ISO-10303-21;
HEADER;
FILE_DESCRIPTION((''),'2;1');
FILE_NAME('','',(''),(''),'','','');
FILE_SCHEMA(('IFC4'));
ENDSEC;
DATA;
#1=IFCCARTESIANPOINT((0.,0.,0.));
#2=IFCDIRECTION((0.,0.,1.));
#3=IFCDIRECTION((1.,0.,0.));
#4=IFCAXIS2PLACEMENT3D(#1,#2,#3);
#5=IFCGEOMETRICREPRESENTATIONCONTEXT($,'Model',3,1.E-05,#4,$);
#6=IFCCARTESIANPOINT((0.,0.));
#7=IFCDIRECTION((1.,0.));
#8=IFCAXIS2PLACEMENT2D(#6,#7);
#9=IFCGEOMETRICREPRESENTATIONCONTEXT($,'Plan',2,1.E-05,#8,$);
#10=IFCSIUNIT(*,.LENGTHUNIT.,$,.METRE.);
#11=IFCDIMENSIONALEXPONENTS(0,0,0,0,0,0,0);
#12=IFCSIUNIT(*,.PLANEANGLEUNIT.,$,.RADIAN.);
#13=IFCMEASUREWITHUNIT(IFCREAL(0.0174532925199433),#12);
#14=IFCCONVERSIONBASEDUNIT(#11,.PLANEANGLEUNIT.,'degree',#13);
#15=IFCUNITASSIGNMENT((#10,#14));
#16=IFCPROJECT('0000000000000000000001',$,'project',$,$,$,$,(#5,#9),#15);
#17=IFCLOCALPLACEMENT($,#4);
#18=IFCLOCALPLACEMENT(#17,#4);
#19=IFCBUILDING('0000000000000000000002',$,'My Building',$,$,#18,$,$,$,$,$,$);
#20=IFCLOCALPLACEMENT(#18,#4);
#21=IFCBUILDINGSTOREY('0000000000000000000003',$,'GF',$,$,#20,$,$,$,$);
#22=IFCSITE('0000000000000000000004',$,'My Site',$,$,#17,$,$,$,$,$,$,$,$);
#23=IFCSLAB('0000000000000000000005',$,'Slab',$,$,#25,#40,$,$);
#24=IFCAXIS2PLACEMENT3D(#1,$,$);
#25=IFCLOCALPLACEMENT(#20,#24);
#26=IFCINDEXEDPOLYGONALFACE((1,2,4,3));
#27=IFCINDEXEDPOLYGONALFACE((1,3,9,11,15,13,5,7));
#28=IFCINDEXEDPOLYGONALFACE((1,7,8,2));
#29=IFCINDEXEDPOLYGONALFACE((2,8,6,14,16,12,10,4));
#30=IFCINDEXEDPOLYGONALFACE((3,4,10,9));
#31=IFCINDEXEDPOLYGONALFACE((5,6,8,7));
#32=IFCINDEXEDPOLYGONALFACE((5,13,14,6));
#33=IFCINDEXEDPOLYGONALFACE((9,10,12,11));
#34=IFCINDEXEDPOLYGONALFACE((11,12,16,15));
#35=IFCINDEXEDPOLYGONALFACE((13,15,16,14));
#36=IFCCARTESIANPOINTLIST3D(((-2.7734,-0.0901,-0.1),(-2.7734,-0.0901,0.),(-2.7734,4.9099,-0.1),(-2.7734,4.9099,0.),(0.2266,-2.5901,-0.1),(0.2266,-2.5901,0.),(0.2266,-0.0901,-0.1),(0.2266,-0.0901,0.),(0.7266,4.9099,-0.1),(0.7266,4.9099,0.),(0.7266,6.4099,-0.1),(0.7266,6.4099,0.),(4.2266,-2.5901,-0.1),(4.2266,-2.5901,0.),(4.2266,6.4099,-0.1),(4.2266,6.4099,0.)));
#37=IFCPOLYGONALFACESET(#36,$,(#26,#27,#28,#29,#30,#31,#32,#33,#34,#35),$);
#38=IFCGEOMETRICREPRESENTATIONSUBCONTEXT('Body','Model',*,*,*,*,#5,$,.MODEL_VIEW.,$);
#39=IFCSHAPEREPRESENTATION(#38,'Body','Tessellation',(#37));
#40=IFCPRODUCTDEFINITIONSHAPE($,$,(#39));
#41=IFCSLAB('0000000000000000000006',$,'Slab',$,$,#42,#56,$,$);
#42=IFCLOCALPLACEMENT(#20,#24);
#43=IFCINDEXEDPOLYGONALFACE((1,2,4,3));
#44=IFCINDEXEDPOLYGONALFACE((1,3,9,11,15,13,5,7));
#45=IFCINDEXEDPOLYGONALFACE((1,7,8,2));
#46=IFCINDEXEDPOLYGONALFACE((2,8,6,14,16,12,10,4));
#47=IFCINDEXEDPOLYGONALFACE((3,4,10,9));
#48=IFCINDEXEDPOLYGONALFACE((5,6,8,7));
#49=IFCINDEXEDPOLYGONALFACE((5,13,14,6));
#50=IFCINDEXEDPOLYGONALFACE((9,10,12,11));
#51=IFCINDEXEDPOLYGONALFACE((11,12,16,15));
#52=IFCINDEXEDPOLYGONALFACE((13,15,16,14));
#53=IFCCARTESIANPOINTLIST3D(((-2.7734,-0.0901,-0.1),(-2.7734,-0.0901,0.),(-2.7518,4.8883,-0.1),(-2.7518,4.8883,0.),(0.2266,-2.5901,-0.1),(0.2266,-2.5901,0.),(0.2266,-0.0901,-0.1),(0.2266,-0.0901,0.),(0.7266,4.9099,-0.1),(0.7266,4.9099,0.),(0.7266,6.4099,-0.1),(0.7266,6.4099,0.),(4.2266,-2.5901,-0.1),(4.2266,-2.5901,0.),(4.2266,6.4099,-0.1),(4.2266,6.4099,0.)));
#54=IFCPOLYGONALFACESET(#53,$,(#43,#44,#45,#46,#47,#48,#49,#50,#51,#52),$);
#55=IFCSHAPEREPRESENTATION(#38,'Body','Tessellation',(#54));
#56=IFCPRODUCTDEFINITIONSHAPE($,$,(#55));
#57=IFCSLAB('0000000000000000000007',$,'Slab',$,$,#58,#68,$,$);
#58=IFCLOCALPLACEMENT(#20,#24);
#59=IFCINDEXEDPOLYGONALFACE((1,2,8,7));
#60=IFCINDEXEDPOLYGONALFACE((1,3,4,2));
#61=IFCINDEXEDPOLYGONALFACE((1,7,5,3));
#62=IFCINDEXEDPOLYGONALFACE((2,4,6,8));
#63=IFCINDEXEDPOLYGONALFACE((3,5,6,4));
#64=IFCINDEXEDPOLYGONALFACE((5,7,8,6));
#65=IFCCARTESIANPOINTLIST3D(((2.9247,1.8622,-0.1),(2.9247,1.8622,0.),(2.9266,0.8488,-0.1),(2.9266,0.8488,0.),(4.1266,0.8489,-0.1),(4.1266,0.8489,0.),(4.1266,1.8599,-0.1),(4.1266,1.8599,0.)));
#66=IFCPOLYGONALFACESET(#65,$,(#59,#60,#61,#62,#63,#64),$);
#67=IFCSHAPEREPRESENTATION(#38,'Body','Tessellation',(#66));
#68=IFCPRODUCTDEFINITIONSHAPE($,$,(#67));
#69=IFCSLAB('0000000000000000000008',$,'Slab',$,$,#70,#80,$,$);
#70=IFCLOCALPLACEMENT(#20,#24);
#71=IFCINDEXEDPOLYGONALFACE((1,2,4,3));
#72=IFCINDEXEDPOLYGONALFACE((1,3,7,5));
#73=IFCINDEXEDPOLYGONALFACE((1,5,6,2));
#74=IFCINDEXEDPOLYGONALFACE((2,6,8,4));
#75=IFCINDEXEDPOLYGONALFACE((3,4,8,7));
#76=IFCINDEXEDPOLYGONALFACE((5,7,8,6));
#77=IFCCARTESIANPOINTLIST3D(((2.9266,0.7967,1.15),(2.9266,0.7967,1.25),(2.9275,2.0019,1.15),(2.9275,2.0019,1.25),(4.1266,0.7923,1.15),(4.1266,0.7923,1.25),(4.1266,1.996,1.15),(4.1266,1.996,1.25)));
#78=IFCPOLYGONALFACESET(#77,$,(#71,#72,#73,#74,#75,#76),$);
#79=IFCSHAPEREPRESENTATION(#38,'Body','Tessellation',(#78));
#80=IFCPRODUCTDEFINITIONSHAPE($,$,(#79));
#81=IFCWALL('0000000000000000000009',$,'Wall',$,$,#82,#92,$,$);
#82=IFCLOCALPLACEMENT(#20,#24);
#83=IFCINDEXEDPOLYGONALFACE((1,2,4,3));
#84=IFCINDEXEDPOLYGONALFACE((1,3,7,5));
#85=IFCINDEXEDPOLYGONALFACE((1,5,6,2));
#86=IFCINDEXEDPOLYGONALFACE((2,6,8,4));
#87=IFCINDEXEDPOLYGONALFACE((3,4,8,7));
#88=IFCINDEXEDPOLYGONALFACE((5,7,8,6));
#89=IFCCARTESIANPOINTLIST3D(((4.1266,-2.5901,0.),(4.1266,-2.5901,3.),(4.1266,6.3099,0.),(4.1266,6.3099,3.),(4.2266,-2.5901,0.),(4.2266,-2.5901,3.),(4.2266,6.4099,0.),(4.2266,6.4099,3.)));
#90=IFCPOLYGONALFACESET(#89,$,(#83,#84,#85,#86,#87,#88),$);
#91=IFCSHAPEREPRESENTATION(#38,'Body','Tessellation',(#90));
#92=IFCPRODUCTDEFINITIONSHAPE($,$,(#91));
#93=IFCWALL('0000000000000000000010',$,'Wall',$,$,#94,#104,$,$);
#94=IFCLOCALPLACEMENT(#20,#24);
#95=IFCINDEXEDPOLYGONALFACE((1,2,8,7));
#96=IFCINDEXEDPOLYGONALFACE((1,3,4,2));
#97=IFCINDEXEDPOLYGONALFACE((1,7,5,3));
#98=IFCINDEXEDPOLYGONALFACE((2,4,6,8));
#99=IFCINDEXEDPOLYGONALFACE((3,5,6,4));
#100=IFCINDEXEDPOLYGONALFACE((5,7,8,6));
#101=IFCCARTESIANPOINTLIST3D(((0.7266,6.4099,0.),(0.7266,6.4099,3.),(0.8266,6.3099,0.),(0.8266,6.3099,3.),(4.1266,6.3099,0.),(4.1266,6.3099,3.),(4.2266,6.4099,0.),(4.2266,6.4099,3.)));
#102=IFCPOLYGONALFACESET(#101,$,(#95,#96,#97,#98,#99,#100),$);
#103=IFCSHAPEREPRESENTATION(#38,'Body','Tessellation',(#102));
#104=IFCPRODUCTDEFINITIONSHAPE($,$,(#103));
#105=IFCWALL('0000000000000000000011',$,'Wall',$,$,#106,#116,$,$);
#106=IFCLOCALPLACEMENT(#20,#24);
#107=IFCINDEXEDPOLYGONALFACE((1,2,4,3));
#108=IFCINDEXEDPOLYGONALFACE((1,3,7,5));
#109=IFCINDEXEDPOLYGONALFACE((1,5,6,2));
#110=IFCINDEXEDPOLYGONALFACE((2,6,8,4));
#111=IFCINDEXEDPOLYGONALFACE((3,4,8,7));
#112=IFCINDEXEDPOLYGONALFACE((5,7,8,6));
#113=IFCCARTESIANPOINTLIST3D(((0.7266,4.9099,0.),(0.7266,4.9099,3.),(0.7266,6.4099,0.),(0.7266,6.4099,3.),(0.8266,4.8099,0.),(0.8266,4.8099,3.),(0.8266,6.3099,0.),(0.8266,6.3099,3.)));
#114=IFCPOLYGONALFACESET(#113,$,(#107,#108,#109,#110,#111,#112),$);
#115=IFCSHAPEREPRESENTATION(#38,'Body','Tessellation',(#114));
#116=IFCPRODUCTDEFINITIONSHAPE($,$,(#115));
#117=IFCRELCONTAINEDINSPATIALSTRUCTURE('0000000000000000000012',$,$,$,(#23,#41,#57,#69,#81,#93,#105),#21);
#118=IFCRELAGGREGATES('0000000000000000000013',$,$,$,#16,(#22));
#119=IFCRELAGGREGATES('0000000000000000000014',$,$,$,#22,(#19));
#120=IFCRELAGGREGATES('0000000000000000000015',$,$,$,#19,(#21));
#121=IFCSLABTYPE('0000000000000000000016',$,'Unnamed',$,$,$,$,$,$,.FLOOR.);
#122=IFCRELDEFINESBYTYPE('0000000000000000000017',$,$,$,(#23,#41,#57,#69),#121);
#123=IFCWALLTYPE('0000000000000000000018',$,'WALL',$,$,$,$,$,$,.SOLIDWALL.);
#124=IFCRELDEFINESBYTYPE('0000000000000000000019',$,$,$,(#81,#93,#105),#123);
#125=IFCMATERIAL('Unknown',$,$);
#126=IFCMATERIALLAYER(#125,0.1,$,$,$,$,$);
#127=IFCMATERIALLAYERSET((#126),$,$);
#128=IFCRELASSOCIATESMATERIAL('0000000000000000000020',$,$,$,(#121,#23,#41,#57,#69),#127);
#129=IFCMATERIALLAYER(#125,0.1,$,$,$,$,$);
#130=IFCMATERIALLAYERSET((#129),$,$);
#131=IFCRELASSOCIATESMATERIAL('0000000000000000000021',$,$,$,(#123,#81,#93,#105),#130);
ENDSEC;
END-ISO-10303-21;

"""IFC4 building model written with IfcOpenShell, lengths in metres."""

from ifc_helpers import new_model, entity, si_unit, converted_unit, frame, origin_with_axes, origin_2d_with_axis, place, context, subcontext, project, spatial, line, indexed_curve, outline, extrude, material, layer, layer_set, layer_usage, type_object, element, save


model = new_model("IFC4")

# Units and contexts
model_context = context("Model", 3, precision=1e-05, world=origin_with_axes())
plan_context = context("Plan", 2, precision=1e-05, world=origin_2d_with_axis())
body_context_1 = subcontext(model_context, "Body", "Model", "MODEL_VIEW")
ifc_project = project(units=[si_unit("LENGTHUNIT", "METRE"), converted_unit("PLANEANGLEUNIT", "degree", entity("IfcReal", 0.0174532925199433), si_unit("PLANEANGLEUNIT", "RADIAN"), dimensions=[0, 0, 0, 0, 0, 0, 0])], contexts=[model_context, plan_context])

# Site, building, storey
site_placement = place(None, origin_with_axes())
site = spatial("IfcSite", under=ifc_project, at=site_placement, Name="My Site")
building_placement = place(site_placement, origin_with_axes())
building = spatial("IfcBuilding", under=site, at=building_placement, Name="My Building")
storey_placement = place(building_placement, origin_with_axes())
storey = spatial("IfcBuildingStorey", under=building, at=storey_placement, Name="GF")

# Slabs
ifc_material_1 = material(Name="Unknown")
ifc_layer_1 = layer(ifc_material_1, 0.1)
ifc_layer_set_1 = layer_set([ifc_layer_1])
ifc_layer_usage_1 = layer_usage(ifc_layer_set_1, "AXIS3", "POSITIVE", -0.1)
slab_type = type_object("IfcSlabType", Name="Unnamed", PredefinedType="FLOOR", material=ifc_layer_set_1)
slab_1_placement = place(storey_placement, frame((4.2266, -2.5901, 0.0), z_axis=(0.0, 0.0, 1.0), x_axis=(1.0, 0.0, 0.0)))
element("IfcSlab", 1, at=slab_1_placement, inside=storey, type_object=slab_type, material=ifc_layer_usage_1, Name="Slab", context=body_context_1, shape_type="SweptSolid", body=[
    extrude(outline(indexed_curve([(0.0, 0.0), (0.0, 9.0), (-3.5, 9.0), (-3.5, 7.5), (-7.0, 7.5), (-7.0, 2.5), (-4.0, 2.5), (-4.0, 0.0), (0.0, 0.0)])), frame((0.0, 0.0, -0.1), z_axis=(0.0, 0.0, 1.0), x_axis=(1.0, 0.0, 0.0)), (0.0, 0.0, 1.0), 0.1),
])
ifc_layer_usage_2 = layer_usage(ifc_layer_set_1, "AXIS3", "POSITIVE", -0.1)
slab_2_placement = place(storey_placement, frame((0.7266, 6.4099, 0.0), z_axis=(0.0, 0.0, 1.0), x_axis=(1.0, 0.0, 0.0)))
element("IfcSlab", 2, at=slab_2_placement, inside=storey, type_object=slab_type, material=ifc_layer_usage_2, Name="Slab", context=body_context_1, shape_type="SweptSolid", body=[
    extrude(outline(indexed_curve([(0.0, 0.0), (3.5, 0.0), (3.5, -9.0), (-0.5, -9.0), (-0.5, -6.5), (-3.5, -6.5), (-3.4784, -1.5216), (0.0, -1.5), (0.0, 0.0)])), frame((0.0, 0.0, -0.1), z_axis=(0.0, 0.0, 1.0), x_axis=(1.0, 0.0, 0.0)), (0.0, 0.0, 1.0), 0.1),
])
ifc_layer_usage_3 = layer_usage(ifc_layer_set_1, "AXIS3", "POSITIVE", -0.1)
slab_3_placement = place(storey_placement, frame((2.9266, 0.8488, 0.0), z_axis=(0.0, 0.0, 1.0), x_axis=(1.0, 0.0, 0.0)))
element("IfcSlab", 3, at=slab_3_placement, inside=storey, type_object=slab_type, material=ifc_layer_usage_3, Name="Slab", context=body_context_1, shape_type="SweptSolid", body=[
    extrude(outline(indexed_curve([(0.0, 0.0), (1.2, 0.0001), (1.2, 1.0111), (-0.0019, 1.0134), (0.0, 0.0)])), frame((0.0, 0.0, -0.1), z_axis=(0.0, 0.0, 1.0), x_axis=(1.0, 0.0, 0.0)), (0.0, 0.0, 1.0), 0.1),
])
ifc_layer_usage_4 = layer_usage(ifc_layer_set_1, "AXIS3", "POSITIVE", -0.1)
slab_4_placement = place(storey_placement, frame((2.9266, 0.7967, 1.25), z_axis=(0.0, 0.0, 1.0), x_axis=(1.0, 0.0, 0.0)))
element("IfcSlab", 4, at=slab_4_placement, inside=storey, type_object=slab_type, material=ifc_layer_usage_4, Name="Slab", context=body_context_1, shape_type="SweptSolid", body=[
    extrude(outline(indexed_curve([(0.0, 0.0), (1.2, -0.0044), (1.2, 1.1993), (0.0009, 1.2051), (0.0, 0.0)])), frame((0.0, 0.0, -0.1), z_axis=(0.0, 0.0, 1.0), x_axis=(1.0, 0.0, 0.0)), (0.0, 0.0, 1.0), 0.1),
])

# Walls
ifc_layer_2 = layer(ifc_material_1, 0.1)
ifc_layer_set_2 = layer_set([ifc_layer_2])
ifc_layer_usage_5 = layer_usage(ifc_layer_set_2, "AXIS2", "POSITIVE", 0.0)
wall_type = type_object("IfcWallType", Name="WALL", PredefinedType="SOLIDWALL", material=ifc_layer_set_2)
wall_1_placement = place(storey_placement, frame((4.2266, -2.5901, 0.0), z_axis=(0.0, 0.0, 1.0), x_axis=(0.0, 1.0, 0.0)))
element("IfcWall", 5, at=wall_1_placement, inside=storey, type_object=wall_type, material=ifc_layer_usage_5, Name="Wall", context=body_context_1, shape_type="SweptSolid", body=[
    extrude(outline(indexed_curve([(0.0, 0.0), (0.0, 0.1), (8.9, 0.1), (9.0, 0.0)], segments=[line(1, 2, 3, 4, 1)])), origin_with_axes(), (0.0, 0.0, 1.0), 3.0),
])
ifc_layer_usage_6 = layer_usage(ifc_layer_set_2, "AXIS2", "POSITIVE", 0.0)
wall_2_placement = place(storey_placement, frame((4.2266, 6.4099, 0.0), z_axis=(0.0, 0.0, 1.0), x_axis=(-1.0, 0.0, 0.0)))
element("IfcWall", 6, at=wall_2_placement, inside=storey, type_object=wall_type, material=ifc_layer_usage_6, Name="Wall", context=body_context_1, shape_type="SweptSolid", body=[
    extrude(outline(indexed_curve([(0.0, 0.0), (0.1, 0.1), (3.4, 0.1), (3.5, 0.0)], segments=[line(1, 2, 3, 4, 1)])), origin_with_axes(), (0.0, 0.0, 1.0), 3.0),
])
ifc_layer_usage_7 = layer_usage(ifc_layer_set_2, "AXIS2", "POSITIVE", 0.0)
wall_3_placement = place(storey_placement, frame((0.7266, 6.4099, 0.0), z_axis=(0.0, 0.0, 1.0), x_axis=(0.0, -1.0, 0.0)))
element("IfcWall", 7, at=wall_3_placement, inside=storey, type_object=wall_type, material=ifc_layer_usage_7, Name="Wall", context=body_context_1, shape_type="SweptSolid", body=[
    extrude(outline(indexed_curve([(0.0, 0.0), (0.1, 0.1), (1.6, 0.1), (1.5, 0.0)], segments=[line(1, 2, 3, 4, 1)])), origin_with_axes(), (0.0, 0.0, 1.0), 3.0),
])

save(model, "model.ifc")
